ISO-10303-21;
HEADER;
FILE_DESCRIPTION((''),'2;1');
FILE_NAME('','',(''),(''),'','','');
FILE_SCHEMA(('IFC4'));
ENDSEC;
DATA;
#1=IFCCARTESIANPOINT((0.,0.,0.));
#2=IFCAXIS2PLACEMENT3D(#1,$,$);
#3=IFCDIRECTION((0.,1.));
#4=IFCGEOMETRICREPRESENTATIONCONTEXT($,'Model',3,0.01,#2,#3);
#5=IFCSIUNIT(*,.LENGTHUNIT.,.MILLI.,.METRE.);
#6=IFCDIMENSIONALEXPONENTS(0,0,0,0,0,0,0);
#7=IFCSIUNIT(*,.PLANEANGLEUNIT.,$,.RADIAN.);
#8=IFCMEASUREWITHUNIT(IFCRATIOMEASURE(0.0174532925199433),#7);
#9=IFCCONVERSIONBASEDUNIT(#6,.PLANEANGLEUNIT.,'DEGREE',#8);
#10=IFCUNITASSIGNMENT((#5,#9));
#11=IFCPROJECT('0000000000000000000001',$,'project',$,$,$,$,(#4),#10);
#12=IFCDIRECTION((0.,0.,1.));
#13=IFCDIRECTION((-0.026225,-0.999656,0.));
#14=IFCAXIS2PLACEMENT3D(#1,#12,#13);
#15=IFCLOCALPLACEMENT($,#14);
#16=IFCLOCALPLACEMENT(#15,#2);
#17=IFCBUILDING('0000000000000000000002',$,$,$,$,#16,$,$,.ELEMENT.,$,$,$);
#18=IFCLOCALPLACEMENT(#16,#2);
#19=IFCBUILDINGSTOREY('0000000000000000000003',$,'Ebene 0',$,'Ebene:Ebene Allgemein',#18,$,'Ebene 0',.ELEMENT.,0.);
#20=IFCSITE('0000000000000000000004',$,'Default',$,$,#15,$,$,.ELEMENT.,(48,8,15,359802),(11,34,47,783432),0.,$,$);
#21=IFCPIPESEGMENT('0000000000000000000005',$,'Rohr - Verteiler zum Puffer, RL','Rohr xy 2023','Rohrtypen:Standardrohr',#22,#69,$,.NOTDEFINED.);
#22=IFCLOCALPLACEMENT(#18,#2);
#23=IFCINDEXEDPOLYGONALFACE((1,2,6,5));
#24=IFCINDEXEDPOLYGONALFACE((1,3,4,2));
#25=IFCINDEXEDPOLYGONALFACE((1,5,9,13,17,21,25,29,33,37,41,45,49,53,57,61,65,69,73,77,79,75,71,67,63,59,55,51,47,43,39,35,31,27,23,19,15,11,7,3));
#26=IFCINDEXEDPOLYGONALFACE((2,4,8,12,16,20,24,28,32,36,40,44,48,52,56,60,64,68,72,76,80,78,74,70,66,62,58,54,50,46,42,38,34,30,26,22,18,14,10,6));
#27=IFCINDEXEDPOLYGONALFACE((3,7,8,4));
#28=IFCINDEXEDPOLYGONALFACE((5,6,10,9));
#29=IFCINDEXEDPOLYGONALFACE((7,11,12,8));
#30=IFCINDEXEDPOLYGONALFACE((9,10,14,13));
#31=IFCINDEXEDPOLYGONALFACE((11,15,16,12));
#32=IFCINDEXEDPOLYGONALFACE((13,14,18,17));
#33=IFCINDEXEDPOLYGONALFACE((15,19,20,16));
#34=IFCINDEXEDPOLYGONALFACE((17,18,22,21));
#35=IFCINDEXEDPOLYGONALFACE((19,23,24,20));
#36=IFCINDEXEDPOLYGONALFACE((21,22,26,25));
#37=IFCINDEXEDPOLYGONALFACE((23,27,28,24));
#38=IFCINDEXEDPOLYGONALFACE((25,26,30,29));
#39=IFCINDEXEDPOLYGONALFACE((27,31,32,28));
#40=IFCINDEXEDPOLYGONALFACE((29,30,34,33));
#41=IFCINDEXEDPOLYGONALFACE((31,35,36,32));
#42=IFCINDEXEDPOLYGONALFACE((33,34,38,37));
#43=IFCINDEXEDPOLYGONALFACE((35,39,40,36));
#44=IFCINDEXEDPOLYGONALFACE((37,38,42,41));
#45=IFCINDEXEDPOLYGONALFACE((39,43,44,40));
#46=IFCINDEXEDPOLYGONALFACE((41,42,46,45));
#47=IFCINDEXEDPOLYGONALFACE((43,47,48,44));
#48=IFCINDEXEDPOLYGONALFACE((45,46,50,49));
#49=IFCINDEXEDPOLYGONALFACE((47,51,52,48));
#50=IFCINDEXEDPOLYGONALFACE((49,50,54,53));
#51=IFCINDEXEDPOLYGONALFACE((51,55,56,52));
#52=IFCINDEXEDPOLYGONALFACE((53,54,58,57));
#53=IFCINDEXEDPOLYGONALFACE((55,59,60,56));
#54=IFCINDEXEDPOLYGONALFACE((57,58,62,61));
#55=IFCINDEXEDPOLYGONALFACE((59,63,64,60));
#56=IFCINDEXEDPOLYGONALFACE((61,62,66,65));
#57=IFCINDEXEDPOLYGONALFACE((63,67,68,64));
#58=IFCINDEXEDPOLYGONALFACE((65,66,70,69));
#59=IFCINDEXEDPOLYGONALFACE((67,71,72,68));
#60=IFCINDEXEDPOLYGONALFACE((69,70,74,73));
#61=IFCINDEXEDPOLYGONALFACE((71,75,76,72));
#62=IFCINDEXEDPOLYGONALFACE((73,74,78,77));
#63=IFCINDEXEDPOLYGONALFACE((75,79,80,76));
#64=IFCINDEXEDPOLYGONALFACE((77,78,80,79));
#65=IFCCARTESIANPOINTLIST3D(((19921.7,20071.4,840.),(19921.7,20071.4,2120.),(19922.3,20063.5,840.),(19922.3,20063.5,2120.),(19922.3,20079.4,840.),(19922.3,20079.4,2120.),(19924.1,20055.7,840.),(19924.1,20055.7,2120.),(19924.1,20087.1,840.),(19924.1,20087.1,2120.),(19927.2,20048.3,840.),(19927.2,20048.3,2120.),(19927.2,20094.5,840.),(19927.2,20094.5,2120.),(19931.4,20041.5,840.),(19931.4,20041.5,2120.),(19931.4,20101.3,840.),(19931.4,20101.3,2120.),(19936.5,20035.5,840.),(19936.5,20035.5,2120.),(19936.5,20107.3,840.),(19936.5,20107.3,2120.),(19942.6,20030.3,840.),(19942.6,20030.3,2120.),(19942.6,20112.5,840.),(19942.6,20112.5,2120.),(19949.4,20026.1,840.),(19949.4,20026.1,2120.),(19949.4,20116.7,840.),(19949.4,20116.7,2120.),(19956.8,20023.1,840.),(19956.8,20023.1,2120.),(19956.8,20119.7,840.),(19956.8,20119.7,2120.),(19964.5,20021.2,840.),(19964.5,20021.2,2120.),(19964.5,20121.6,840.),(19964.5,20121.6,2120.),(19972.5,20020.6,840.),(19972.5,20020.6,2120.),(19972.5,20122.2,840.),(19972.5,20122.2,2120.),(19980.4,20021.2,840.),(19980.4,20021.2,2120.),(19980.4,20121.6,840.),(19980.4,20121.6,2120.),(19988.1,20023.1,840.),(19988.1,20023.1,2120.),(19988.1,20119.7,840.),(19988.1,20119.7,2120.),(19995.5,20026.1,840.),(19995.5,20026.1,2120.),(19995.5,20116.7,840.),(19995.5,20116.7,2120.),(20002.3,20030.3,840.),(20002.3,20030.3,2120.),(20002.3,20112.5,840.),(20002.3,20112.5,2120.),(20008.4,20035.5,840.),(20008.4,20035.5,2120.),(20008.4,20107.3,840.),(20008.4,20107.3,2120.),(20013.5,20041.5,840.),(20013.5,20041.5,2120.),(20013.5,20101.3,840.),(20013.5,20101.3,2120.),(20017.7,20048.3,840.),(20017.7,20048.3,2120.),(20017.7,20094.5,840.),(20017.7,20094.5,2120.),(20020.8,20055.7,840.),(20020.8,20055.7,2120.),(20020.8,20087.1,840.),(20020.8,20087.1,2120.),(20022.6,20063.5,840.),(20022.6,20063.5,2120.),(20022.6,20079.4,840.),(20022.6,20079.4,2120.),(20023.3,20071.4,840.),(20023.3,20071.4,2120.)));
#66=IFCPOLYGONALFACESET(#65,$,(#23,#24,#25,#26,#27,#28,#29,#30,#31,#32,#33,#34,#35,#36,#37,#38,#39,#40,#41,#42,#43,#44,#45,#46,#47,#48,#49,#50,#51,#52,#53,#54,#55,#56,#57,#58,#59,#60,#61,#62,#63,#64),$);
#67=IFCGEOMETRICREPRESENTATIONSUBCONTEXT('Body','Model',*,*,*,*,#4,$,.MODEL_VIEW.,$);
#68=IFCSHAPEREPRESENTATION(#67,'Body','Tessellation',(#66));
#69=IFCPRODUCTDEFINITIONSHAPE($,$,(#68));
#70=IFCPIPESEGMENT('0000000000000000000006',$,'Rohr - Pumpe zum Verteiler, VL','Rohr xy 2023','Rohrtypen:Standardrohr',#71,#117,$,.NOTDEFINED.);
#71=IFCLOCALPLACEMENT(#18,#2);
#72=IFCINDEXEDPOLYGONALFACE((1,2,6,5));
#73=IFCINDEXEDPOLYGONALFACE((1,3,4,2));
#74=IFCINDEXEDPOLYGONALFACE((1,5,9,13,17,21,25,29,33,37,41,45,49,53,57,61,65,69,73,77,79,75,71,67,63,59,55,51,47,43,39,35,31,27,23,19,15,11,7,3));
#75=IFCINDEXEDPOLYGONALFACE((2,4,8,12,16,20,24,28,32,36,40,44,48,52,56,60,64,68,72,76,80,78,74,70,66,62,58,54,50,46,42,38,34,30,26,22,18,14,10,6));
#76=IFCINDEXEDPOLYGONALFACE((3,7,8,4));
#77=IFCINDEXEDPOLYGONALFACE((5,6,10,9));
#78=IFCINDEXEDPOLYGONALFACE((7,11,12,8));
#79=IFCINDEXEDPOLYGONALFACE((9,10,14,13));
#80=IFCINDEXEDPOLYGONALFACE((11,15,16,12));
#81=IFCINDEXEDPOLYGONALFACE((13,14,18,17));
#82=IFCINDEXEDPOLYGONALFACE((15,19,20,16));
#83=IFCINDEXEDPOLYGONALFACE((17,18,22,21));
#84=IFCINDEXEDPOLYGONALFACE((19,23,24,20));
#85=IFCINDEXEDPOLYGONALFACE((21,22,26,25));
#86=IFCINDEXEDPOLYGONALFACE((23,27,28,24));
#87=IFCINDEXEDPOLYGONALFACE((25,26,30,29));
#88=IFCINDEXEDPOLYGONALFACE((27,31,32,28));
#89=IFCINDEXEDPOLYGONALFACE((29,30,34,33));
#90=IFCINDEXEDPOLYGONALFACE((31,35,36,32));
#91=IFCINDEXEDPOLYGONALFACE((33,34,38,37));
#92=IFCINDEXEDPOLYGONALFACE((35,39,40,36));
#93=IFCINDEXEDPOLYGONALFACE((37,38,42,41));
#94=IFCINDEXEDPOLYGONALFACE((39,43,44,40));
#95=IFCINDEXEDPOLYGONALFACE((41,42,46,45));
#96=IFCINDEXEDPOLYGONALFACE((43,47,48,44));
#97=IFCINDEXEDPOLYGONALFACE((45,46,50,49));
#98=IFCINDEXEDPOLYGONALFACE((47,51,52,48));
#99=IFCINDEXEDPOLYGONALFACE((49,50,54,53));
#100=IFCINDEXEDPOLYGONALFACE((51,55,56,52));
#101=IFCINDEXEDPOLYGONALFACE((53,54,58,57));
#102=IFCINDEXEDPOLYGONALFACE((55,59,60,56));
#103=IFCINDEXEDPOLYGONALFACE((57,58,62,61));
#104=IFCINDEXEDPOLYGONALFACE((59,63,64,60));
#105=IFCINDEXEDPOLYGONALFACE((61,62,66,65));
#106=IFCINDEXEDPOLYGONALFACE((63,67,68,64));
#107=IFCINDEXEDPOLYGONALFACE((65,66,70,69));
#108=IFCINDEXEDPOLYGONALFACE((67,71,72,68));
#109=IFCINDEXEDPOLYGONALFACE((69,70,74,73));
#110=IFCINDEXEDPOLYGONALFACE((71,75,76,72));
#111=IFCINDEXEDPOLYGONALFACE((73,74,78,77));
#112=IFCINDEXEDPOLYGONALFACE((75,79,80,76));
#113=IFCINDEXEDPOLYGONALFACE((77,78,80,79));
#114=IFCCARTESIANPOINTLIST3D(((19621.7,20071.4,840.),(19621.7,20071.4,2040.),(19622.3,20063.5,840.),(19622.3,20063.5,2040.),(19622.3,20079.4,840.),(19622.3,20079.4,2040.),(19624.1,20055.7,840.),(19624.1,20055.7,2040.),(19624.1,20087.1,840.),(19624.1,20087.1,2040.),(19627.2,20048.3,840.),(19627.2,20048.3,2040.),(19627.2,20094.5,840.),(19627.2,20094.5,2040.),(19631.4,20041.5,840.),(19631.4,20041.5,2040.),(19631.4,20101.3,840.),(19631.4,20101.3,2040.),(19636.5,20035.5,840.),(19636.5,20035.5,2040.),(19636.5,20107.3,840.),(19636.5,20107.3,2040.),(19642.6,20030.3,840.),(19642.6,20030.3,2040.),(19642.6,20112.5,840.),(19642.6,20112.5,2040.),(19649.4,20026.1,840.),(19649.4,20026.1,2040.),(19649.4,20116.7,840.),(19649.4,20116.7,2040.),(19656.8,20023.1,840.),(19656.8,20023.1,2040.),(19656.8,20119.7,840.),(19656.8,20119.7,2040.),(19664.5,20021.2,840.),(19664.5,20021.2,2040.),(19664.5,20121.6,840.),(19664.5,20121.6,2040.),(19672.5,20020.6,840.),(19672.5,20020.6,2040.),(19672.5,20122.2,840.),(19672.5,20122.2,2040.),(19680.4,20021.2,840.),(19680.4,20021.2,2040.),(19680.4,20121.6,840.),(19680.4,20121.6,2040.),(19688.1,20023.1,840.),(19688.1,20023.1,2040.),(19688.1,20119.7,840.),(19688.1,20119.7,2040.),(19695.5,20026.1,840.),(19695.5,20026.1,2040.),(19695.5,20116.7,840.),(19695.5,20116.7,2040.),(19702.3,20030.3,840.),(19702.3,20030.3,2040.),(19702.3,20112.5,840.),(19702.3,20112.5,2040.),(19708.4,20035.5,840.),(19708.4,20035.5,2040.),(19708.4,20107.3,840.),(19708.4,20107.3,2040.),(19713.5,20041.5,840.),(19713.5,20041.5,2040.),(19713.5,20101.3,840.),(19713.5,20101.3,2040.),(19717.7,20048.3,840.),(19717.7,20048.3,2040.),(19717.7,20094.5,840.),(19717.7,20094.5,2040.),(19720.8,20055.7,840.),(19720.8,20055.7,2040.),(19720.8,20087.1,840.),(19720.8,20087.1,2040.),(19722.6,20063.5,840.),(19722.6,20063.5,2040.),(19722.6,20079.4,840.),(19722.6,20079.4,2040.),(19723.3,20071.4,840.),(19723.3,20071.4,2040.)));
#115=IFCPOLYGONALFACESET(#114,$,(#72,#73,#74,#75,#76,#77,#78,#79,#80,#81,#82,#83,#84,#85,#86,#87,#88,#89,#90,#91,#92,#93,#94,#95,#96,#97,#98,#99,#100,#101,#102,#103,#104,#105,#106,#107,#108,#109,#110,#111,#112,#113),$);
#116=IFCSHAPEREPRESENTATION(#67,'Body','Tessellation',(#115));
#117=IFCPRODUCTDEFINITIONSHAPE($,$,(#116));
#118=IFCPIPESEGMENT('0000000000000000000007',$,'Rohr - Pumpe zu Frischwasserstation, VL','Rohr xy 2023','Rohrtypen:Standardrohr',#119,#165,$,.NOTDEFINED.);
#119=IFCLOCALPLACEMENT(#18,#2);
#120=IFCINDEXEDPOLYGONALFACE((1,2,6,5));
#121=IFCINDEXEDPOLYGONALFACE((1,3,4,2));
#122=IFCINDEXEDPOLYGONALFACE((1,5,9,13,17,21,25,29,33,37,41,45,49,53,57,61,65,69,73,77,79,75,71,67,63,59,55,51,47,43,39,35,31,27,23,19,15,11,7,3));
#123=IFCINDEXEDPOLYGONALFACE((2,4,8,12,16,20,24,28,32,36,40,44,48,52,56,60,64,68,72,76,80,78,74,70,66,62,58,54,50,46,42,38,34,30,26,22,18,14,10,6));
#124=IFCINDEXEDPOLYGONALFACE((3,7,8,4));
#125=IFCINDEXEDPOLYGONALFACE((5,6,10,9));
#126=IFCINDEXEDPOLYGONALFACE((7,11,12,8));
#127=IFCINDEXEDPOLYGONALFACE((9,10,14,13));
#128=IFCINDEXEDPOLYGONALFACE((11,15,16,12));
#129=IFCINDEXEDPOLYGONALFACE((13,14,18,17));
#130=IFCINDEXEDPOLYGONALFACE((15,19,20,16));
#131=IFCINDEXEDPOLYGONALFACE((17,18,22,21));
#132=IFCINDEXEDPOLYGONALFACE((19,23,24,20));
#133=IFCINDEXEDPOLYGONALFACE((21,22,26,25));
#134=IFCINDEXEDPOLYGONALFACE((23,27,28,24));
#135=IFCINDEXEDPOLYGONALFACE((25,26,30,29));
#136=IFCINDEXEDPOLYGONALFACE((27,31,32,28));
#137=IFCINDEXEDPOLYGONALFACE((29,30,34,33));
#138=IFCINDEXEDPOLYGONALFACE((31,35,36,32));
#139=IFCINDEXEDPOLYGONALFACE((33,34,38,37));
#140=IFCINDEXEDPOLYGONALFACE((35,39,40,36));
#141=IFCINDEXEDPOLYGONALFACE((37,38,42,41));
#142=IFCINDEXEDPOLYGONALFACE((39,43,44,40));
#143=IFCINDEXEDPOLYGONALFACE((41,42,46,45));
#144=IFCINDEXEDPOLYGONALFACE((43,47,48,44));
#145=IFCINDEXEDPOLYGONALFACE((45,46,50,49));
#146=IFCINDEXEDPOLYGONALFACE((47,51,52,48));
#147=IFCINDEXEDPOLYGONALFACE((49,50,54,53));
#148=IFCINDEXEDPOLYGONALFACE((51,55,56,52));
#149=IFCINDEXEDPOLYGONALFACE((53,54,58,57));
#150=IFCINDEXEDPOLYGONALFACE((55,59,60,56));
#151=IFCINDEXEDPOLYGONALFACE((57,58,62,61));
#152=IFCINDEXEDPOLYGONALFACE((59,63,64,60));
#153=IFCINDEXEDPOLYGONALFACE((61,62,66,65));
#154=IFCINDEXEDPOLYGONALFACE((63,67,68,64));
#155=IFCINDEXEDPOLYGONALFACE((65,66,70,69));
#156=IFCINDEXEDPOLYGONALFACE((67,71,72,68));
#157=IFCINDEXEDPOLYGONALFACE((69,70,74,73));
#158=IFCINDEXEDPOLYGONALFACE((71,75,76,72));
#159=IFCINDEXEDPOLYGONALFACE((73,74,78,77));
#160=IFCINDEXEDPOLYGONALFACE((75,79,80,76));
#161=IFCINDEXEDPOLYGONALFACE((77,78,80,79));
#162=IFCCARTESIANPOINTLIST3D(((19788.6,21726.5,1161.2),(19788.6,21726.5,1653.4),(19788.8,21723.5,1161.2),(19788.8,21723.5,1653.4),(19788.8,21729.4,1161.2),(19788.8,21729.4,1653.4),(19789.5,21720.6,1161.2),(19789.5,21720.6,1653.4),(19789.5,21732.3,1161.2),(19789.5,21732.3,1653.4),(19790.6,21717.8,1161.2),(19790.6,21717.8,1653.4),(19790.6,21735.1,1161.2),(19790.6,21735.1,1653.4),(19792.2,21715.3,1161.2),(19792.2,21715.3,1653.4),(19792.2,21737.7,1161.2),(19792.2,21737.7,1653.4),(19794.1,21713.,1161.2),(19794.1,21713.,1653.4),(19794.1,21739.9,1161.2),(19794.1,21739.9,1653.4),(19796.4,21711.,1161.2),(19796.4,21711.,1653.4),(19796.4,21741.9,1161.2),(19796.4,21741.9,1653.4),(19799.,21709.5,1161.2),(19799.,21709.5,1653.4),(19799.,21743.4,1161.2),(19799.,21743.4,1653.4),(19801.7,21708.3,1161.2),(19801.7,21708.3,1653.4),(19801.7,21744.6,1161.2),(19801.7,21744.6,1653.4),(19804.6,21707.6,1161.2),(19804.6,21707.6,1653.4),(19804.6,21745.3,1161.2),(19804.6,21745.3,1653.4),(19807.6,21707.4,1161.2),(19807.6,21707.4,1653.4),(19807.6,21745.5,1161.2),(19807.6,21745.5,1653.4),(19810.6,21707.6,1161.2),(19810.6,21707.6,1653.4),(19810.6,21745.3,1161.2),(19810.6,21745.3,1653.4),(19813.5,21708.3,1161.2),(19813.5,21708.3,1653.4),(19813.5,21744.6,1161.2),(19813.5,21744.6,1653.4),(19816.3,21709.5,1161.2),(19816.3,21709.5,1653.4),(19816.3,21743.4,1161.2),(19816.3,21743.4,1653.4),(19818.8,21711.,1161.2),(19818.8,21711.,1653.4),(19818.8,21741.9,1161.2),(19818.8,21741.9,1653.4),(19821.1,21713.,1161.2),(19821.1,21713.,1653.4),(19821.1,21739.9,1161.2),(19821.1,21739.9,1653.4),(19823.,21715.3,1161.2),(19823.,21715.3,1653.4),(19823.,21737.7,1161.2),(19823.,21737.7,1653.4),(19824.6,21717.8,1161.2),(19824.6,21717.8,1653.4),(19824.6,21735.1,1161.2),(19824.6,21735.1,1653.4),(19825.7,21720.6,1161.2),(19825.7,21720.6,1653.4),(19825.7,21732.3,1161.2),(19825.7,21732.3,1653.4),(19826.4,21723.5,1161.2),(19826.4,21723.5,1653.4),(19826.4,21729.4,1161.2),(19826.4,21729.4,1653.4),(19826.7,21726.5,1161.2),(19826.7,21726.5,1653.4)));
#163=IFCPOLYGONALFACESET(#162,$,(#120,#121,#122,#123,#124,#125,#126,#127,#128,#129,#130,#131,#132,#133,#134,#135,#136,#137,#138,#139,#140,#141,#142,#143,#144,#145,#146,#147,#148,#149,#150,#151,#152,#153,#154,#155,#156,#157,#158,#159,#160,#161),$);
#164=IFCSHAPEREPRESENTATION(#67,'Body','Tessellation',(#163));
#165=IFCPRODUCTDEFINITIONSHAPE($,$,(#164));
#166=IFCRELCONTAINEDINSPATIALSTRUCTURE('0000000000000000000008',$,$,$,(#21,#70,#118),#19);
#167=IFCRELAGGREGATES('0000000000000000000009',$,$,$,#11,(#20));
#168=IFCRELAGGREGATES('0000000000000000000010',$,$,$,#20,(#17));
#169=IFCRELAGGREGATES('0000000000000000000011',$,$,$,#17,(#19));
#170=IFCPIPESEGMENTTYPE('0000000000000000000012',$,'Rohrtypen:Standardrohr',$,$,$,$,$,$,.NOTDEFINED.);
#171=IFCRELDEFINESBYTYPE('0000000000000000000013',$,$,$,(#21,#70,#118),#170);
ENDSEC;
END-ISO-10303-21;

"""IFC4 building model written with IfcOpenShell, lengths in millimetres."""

from ifc_helpers import new_model, entity, si_unit, converted_unit, direction, frame, origin, place, context, subcontext, project, spatial, indexed_curve, outline, extrude, type_object, element, save


model = new_model("IFC4")

# Units and contexts
model_context = context("Model", 3, precision=0.01, world=origin(), true_north=direction((0.0, 1.0)))
body_context = subcontext(model_context, "Body", "Model", "MODEL_VIEW")
ifc_project = project(units=[si_unit("LENGTHUNIT", "METRE", prefix="MILLI"), converted_unit("PLANEANGLEUNIT", "DEGREE", entity("IfcRatioMeasure", 0.0174532925199433), si_unit("PLANEANGLEUNIT", "RADIAN"), dimensions=[0, 0, 0, 0, 0, 0, 0])], contexts=[model_context])

# Site, building, storey
site_placement = place(None, frame((0.0, 0.0, 0.0), z_axis=(0.0, 0.0, 1.0), x_axis=(-0.026225, -0.999656, 0.0)))
site = spatial("IfcSite", under=ifc_project, at=site_placement, Name="Default", CompositionType="ELEMENT", RefLatitude=(48, 8, 15, 359802), RefLongitude=(11, 34, 47, 783432), RefElevation=0.0)
building_placement = place(site_placement, origin())
building = spatial("IfcBuilding", under=site, at=building_placement, CompositionType="ELEMENT")
storey_placement = place(building_placement, origin())
storey = spatial("IfcBuildingStorey", under=building, at=storey_placement, Name="Ebene 0", ObjectType="Ebene:Ebene Allgemein", LongName="Ebene 0", CompositionType="ELEMENT", Elevation=0.0)

# Pipe segments
pipe_segment_type = type_object("IfcPipeSegmentType", Name="Rohrtypen:Standardrohr", PredefinedType="NOTDEFINED")
pipe_segment_1_placement = place(storey_placement, origin())
element("IfcPipeSegment", 1, at=pipe_segment_1_placement, inside=storey, type_object=pipe_segment_type, Name="Rohr - Verteiler zum Puffer, RL", Description="Rohr xy 2023", ObjectType="Rohrtypen:Standardrohr", PredefinedType="NOTDEFINED", context=body_context, shape_type="SweptSolid", body=[
    extrude(outline(indexed_curve([(50.8, 0.0), (50.2, 7.9), (48.3, 15.7), (45.3, 23.1), (41.1, 29.9), (35.9, 35.9), (29.9, 41.1), (23.1, 45.3), (15.7, 48.3), (7.9, 50.2), (0.0, 50.8), (-7.9, 50.2), (-15.7, 48.3), (-23.1, 45.3), (-29.9, 41.1), (-35.9, 35.9), (-41.1, 29.9), (-45.3, 23.1), (-48.3, 15.7), (-50.2, 7.9), (-50.8, 0.0), (-50.2, -7.9), (-48.3, -15.7), (-45.3, -23.1), (-41.1, -29.9), (-35.9, -35.9), (-29.9, -41.1), (-23.1, -45.3), (-15.7, -48.3), (-7.9, -50.2), (0.0, -50.8), (7.9, -50.2), (15.7, -48.3), (23.1, -45.3), (29.9, -41.1), (35.9, -35.9), (41.1, -29.9), (45.3, -23.1), (48.3, -15.7), (50.2, -7.9), (50.8, 0.0)], self_intersect=False)), frame((19972.5, 20071.4, 840.0), z_axis=(0.0, 0.0, 1.0), x_axis=(-1.0, 0.0, 0.0)), (0.0, 0.0, 1.0), 1280.0),
])
pipe_segment_2_placement = place(storey_placement, origin())
element("IfcPipeSegment", 2, at=pipe_segment_2_placement, inside=storey, type_object=pipe_segment_type, Name="Rohr - Pumpe zum Verteiler, VL", Description="Rohr xy 2023", ObjectType="Rohrtypen:Standardrohr", PredefinedType="NOTDEFINED", context=body_context, shape_type="SweptSolid", body=[
    extrude(outline(indexed_curve([(50.8, 0.0), (50.2, 7.9), (48.3, 15.7), (45.3, 23.1), (41.1, 29.9), (35.9, 35.9), (29.9, 41.1), (23.1, 45.3), (15.7, 48.3), (7.9, 50.2), (0.0, 50.8), (-7.9, 50.2), (-15.7, 48.3), (-23.1, 45.3), (-29.9, 41.1), (-35.9, 35.9), (-41.1, 29.9), (-45.3, 23.1), (-48.3, 15.7), (-50.2, 7.9), (-50.8, 0.0), (-50.2, -7.9), (-48.3, -15.7), (-45.3, -23.1), (-41.1, -29.9), (-35.9, -35.9), (-29.9, -41.1), (-23.1, -45.3), (-15.7, -48.3), (-7.9, -50.2), (0.0, -50.8), (7.9, -50.2), (15.7, -48.3), (23.1, -45.3), (29.9, -41.1), (35.9, -35.9), (41.1, -29.9), (45.3, -23.1), (48.3, -15.7), (50.2, -7.9), (50.8, 0.0)], self_intersect=False)), frame((19672.5, 20071.4, 840.0), z_axis=(0.0, 0.0, 1.0), x_axis=(-1.0, 0.0, 0.0)), (0.0, 0.0, 1.0), 1200.0),
])
pipe_segment_3_placement = place(storey_placement, origin())
element("IfcPipeSegment", 3, at=pipe_segment_3_placement, inside=storey, type_object=pipe_segment_type, Name="Rohr - Pumpe zu Frischwasserstation, VL", Description="Rohr xy 2023", ObjectType="Rohrtypen:Standardrohr", PredefinedType="NOTDEFINED", context=body_context, shape_type="SweptSolid", body=[
    extrude(outline(indexed_curve([(19.1, 0.0), (18.8, 3.0), (18.1, 5.9), (17.0, 8.6), (15.4, 11.2), (13.5, 13.5), (11.2, 15.4), (8.6, 17.0), (5.9, 18.1), (3.0, 18.8), (0.0, 19.0), (-3.0, 18.8), (-5.9, 18.1), (-8.6, 17.0), (-11.2, 15.4), (-13.5, 13.5), (-15.4, 11.2), (-17.0, 8.6), (-18.1, 5.9), (-18.8, 3.0), (-19.1, 0.0), (-18.8, -3.0), (-18.1, -5.9), (-17.0, -8.6), (-15.4, -11.2), (-13.5, -13.5), (-11.2, -15.4), (-8.6, -17.0), (-5.9, -18.1), (-3.0, -18.8), (0.0, -19.0), (3.0, -18.8), (5.9, -18.1), (8.6, -17.0), (11.2, -15.4), (13.5, -13.5), (15.4, -11.2), (17.0, -8.6), (18.1, -5.9), (18.8, -3.0), (19.1, 0.0)], self_intersect=False)), frame((19807.6, 21726.5, 1161.2), z_axis=(0.000002, 0.000002, 1.0), x_axis=(-1.0, 0.0, 0.000002)), (0.0, 0.0, 1.0), 492.1),
])

save(model, "model.ifc")
